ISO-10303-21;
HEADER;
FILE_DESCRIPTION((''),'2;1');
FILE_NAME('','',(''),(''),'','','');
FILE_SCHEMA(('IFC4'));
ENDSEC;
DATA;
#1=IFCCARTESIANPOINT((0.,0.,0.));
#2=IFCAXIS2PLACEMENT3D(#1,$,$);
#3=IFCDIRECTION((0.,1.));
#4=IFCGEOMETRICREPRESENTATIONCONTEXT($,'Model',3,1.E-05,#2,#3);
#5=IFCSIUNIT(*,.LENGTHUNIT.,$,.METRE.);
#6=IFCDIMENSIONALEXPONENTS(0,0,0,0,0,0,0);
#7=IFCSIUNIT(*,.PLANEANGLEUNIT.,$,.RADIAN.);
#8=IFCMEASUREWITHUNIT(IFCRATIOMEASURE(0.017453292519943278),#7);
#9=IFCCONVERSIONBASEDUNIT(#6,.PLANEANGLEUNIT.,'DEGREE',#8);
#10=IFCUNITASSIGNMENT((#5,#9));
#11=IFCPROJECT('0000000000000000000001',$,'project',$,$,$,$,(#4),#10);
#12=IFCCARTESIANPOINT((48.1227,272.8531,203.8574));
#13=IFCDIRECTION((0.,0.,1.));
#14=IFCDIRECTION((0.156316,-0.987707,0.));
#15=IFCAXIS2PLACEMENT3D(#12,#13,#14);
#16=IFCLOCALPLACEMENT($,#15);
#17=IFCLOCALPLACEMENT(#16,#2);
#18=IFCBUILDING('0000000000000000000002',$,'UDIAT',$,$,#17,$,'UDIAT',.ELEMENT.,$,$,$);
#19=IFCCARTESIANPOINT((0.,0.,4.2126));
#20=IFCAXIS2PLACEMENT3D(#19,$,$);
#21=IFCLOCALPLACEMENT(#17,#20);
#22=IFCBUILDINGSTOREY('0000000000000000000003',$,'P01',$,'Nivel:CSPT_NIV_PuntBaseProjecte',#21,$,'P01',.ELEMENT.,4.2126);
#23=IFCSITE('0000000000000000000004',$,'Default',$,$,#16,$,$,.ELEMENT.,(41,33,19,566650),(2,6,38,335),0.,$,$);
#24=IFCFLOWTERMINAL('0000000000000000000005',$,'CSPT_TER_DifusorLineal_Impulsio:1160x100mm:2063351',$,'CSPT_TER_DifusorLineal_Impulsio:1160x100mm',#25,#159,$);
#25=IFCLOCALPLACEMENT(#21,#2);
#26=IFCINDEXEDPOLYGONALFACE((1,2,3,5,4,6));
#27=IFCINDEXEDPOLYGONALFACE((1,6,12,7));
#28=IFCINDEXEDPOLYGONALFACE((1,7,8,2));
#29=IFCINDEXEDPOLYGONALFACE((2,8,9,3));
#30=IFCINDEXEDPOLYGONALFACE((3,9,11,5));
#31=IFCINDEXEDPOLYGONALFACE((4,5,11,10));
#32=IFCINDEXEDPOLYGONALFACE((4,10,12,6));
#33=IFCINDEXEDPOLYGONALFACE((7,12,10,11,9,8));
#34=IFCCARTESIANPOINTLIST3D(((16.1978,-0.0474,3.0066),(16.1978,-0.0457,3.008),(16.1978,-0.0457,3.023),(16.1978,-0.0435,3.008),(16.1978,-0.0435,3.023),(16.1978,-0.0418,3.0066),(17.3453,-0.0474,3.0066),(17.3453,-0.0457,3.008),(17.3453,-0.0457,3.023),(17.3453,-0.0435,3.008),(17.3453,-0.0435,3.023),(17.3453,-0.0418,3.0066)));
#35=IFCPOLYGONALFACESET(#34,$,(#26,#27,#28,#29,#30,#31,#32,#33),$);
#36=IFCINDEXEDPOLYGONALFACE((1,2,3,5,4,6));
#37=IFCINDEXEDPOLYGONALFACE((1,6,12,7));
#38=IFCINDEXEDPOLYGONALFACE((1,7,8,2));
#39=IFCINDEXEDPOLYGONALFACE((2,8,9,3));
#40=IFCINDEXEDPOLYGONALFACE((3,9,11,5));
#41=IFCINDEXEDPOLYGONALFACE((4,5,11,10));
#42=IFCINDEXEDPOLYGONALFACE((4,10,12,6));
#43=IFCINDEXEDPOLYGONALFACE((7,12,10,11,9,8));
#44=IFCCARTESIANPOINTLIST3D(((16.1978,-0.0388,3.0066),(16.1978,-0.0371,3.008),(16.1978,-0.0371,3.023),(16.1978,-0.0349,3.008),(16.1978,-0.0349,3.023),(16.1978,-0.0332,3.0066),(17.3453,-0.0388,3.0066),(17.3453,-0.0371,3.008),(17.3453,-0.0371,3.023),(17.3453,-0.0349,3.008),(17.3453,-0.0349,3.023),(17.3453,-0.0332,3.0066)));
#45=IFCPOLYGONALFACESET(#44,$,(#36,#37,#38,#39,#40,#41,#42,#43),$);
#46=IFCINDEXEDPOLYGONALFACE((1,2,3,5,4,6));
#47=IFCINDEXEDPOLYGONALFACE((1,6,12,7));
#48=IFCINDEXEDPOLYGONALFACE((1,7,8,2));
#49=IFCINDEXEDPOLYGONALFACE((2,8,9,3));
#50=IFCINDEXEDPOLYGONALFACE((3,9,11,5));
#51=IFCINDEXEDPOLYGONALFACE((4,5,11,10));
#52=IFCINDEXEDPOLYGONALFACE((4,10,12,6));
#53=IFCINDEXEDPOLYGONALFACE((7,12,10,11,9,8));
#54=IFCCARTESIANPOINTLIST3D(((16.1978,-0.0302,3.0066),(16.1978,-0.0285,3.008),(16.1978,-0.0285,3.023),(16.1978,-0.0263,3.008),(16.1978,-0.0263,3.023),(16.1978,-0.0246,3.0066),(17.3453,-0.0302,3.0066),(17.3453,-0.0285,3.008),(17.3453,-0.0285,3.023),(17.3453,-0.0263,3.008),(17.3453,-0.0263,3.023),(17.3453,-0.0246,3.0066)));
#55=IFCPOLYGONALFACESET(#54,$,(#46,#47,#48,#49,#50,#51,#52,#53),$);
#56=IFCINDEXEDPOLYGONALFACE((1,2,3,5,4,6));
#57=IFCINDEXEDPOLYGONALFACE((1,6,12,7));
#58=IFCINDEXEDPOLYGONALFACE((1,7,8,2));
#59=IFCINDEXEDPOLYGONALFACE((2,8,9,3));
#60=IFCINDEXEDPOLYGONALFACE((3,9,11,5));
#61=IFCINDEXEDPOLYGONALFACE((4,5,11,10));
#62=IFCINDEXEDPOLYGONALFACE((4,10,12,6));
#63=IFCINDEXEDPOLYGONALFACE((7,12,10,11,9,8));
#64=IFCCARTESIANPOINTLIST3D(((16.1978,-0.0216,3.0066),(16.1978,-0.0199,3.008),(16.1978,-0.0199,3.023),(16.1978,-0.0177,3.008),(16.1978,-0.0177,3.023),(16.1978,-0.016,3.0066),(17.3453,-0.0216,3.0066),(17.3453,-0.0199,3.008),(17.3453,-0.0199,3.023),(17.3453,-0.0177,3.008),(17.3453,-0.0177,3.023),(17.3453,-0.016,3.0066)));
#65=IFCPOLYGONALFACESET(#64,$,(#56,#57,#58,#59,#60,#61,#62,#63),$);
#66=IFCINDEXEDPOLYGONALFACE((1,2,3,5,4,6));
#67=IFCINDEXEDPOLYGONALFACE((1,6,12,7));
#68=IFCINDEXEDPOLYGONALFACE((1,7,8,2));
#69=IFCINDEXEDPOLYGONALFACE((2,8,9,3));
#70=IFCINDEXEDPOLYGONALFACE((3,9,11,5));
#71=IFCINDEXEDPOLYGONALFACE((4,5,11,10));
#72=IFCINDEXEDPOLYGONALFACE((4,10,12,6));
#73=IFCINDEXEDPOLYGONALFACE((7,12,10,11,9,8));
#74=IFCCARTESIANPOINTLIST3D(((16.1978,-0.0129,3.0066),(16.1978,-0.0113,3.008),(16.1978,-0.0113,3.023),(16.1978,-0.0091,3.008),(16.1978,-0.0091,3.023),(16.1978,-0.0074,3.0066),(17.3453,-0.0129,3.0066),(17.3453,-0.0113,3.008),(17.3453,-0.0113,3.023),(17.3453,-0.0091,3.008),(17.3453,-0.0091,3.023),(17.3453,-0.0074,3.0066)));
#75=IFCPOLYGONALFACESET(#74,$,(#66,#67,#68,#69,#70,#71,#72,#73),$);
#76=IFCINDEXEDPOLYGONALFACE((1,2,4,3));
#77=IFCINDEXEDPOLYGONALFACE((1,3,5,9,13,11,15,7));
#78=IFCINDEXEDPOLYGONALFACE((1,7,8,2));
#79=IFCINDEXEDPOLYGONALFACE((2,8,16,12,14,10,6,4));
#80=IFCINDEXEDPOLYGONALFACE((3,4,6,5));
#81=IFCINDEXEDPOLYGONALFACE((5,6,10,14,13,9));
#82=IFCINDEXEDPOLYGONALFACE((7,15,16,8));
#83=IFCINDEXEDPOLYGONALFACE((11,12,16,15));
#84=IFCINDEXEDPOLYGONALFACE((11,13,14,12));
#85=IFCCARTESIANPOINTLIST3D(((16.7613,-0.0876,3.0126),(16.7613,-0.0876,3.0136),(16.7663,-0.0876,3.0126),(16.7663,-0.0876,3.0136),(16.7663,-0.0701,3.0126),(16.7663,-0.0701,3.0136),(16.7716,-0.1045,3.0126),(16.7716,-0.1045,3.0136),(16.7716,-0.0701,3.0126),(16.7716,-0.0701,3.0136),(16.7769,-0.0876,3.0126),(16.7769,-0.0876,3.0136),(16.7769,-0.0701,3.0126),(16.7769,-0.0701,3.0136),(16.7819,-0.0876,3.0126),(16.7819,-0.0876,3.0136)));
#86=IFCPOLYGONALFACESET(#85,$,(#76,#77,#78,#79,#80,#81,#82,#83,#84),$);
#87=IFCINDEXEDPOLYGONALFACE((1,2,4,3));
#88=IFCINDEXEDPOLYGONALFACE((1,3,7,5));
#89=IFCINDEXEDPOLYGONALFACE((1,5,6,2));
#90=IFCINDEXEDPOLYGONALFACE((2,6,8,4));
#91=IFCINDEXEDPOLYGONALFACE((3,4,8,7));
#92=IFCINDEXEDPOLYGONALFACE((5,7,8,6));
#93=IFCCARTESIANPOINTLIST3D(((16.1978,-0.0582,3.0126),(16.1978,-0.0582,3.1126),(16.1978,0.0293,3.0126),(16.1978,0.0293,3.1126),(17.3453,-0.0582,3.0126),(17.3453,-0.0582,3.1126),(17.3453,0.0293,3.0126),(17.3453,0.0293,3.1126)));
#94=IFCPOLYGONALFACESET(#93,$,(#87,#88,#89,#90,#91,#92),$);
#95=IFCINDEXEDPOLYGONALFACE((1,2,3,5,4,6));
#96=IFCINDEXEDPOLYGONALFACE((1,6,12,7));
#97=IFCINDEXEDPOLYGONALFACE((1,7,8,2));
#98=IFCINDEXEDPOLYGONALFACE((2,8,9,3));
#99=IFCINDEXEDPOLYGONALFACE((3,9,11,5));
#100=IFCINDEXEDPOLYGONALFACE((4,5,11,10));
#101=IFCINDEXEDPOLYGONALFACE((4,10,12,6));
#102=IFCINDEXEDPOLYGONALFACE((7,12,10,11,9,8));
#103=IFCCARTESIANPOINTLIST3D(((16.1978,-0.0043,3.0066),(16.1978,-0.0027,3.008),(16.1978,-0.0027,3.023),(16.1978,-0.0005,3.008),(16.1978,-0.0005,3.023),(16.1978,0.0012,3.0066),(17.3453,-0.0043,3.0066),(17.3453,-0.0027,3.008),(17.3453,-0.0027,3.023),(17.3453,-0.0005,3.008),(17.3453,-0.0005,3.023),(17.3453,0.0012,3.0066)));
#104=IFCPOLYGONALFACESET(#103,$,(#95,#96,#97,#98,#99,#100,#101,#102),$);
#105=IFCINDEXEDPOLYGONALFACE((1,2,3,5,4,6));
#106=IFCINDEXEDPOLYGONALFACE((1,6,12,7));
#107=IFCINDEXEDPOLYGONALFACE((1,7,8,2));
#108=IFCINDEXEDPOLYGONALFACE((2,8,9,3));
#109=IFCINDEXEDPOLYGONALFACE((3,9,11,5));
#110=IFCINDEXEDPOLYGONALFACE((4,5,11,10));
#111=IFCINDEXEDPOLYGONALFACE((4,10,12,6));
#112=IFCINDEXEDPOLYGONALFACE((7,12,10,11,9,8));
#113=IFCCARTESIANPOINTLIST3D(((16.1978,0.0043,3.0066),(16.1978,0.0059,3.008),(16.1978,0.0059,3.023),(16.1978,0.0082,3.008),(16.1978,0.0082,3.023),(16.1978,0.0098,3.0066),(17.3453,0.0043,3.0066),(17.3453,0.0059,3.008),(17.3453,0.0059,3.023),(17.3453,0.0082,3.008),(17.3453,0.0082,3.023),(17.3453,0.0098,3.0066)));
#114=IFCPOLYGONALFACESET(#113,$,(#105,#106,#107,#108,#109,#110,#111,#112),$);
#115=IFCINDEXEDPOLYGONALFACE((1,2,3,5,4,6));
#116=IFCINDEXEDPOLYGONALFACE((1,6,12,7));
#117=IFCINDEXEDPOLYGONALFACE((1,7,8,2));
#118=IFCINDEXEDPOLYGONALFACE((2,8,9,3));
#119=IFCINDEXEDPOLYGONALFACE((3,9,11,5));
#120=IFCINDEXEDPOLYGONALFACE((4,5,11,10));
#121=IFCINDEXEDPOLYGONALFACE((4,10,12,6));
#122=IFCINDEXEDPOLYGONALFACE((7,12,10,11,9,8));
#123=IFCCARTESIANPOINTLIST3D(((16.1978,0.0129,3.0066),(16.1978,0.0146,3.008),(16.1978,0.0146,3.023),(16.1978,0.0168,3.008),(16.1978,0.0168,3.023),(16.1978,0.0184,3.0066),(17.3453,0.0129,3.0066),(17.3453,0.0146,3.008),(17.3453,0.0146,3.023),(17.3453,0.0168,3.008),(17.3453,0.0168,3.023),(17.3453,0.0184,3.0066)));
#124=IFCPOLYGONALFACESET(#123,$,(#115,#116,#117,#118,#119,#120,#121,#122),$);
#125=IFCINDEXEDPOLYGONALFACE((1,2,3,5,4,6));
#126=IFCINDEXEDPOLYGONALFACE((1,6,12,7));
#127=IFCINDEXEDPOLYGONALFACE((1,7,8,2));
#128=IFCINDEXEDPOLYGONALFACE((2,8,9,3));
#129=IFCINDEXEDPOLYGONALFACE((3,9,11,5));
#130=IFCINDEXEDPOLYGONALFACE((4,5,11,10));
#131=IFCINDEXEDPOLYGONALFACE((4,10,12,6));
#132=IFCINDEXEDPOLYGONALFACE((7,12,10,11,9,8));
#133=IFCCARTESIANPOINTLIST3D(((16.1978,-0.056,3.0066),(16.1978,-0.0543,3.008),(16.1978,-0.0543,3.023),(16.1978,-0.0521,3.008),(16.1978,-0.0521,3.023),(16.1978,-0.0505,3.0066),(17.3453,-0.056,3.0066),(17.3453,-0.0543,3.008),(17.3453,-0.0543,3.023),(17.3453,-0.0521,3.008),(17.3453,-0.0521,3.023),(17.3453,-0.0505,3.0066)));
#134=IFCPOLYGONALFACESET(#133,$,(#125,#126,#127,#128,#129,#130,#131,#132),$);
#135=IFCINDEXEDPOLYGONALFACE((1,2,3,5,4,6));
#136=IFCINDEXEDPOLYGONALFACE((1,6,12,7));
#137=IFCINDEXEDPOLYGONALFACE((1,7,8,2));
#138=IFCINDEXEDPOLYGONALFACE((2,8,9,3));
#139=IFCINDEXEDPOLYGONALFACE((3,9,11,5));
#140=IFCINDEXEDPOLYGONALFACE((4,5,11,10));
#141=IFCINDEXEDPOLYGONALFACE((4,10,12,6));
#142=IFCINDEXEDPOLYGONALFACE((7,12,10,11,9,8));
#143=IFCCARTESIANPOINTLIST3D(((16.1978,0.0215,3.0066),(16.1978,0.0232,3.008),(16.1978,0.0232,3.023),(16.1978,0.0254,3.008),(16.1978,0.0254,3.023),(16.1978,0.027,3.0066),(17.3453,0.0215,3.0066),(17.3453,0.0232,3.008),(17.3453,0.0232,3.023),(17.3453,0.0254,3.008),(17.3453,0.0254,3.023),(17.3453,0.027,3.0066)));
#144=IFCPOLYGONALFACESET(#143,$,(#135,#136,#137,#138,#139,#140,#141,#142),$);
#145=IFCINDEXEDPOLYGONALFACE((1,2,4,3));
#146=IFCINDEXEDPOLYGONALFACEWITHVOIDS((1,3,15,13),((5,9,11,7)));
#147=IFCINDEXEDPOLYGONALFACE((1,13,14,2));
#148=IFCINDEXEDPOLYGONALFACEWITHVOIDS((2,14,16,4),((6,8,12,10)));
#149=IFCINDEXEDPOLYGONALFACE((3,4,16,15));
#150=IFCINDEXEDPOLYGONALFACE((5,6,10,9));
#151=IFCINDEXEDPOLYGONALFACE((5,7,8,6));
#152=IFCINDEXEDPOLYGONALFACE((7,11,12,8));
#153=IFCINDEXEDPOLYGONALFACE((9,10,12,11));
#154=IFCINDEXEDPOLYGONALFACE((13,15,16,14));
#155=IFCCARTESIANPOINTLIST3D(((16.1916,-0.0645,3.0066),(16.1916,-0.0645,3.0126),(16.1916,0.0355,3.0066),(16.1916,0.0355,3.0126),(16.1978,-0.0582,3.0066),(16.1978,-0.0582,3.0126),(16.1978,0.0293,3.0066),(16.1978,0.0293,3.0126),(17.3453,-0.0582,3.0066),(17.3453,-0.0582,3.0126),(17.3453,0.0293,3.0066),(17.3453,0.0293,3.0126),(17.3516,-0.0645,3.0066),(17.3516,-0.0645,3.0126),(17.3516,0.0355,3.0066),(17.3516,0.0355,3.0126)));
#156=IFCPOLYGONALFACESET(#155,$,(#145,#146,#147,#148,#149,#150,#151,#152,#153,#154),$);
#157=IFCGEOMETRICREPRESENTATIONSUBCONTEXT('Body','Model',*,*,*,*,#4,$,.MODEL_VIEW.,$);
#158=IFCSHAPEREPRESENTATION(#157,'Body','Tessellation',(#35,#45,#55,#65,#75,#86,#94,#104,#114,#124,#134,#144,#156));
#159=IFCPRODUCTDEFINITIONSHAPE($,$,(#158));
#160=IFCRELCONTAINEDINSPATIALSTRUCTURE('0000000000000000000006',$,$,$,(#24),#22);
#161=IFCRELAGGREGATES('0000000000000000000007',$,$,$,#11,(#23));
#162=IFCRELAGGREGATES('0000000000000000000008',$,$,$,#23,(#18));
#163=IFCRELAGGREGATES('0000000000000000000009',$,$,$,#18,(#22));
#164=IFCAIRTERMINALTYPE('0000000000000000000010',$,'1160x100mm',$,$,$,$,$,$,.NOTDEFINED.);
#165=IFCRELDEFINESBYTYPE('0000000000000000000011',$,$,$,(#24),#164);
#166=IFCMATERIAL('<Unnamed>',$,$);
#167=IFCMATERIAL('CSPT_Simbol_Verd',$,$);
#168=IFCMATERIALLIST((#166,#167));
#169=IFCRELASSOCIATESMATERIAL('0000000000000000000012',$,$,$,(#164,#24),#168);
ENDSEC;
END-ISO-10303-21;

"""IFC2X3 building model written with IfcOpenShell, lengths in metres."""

from ifc_helpers import new_model, entity, si_unit, converted_unit, direction, frame, origin, origin_2d_with_axis, place, context, subcontext, project, spatial, polyline, rectangle, outline, extrude, source, transform, mapped, material, material_list, type_object, type_shapes, element, save


model = new_model("IFC2X3")

# Units and contexts
model_context = context("Model", 3, precision=1e-05, world=origin(), true_north=direction((0.0, 1.0)))
body_context = subcontext(model_context, "Body", "Model", "MODEL_VIEW")
ifc_project = project(units=[si_unit("LENGTHUNIT", "METRE"), converted_unit("PLANEANGLEUNIT", "DEGREE", entity("IfcRatioMeasure", 0.017453292519943278), si_unit("PLANEANGLEUNIT", "RADIAN"), dimensions=[0, 0, 0, 0, 0, 0, 0])], contexts=[model_context])

# Site, building, storey
site_placement = place(None, frame((48.1227, 272.8531, 203.8574), z_axis=(0.0, 0.0, 1.0), x_axis=(0.156316, -0.987707, 0.0)))
site = spatial("IfcSite", under=ifc_project, at=site_placement, Name="Default", CompositionType="ELEMENT", RefLatitude=(41, 33, 19, 566650), RefLongitude=(2, 6, 38, 335), RefElevation=0.0)
building_placement = place(site_placement, origin())
building = spatial("IfcBuilding", under=site, at=building_placement, Name="UDIAT", LongName="UDIAT", CompositionType="ELEMENT")
storey_placement = place(building_placement, frame((0.0, 0.0, 4.2126)))
storey = spatial("IfcBuildingStorey", under=building, at=storey_placement, Name="P01", ObjectType="Nivel:CSPT_NIV_PuntBaseProjecte", LongName="P01", CompositionType="ELEMENT", Elevation=4.2126)

# Shared definitions
ifc_material_1 = material(Name="<Unnamed>")

# Flow terminal
ifc_material_2 = material(Name="CSPT_Simbol_Verd")
ifc_material_list = material_list([ifc_material_1, ifc_material_2])
air_terminal_type = type_object("IfcAirTerminalType", Name="1160x100mm", PredefinedType="NOTDEFINED", material=ifc_material_list)
shared_shape_1 = source(origin(), body_context, "Body", "SweptSolid", [
    extrude(outline(polyline([(0.0037, 0.0028), (0.0059, 0.0028), (0.0016, 0.0063), (0.002, 0.0042), (-0.0074, -0.0074), (-0.0057, -0.0088), (0.0037, 0.0028)])), frame((-0.5737, 0.0301, -0.0001), z_axis=(1.0, 0.0, 0.0), x_axis=(0.0, -0.776119, -0.630587)), (0.0, 0.0, 1.0), 1.1475),
    extrude(outline(polyline([(0.0037, 0.0028), (0.0059, 0.0028), (0.0016, 0.0063), (0.002, 0.0042), (-0.0074, -0.0074), (-0.0057, -0.0088), (0.0037, 0.0028)])), frame((-0.5737, 0.0215, -0.0001), z_axis=(1.0, 0.0, 0.0), x_axis=(0.0, -0.776119, -0.630587)), (0.0, 0.0, 1.0), 1.1475),
    extrude(outline(polyline([(0.0037, 0.0028), (0.0059, 0.0028), (0.0016, 0.0063), (0.002, 0.0042), (-0.0074, -0.0074), (-0.0057, -0.0088), (0.0037, 0.0028)])), frame((-0.5737, 0.0129, -0.0001), z_axis=(1.0, 0.0, 0.0), x_axis=(0.0, -0.776119, -0.630587)), (0.0, 0.0, 1.0), 1.1475),
    extrude(outline(polyline([(0.0037, 0.0028), (0.0059, 0.0028), (0.0016, 0.0063), (0.002, 0.0042), (-0.0074, -0.0074), (-0.0057, -0.0088), (0.0037, 0.0028)])), frame((-0.5737, 0.0043, -0.0001), z_axis=(1.0, 0.0, 0.0), x_axis=(0.0, -0.776119, -0.630587)), (0.0, 0.0, 1.0), 1.1475),
    extrude(outline(polyline([(0.0037, 0.0028), (0.0059, 0.0028), (0.0016, 0.0063), (0.002, 0.0042), (-0.0074, -0.0074), (-0.0057, -0.0088), (0.0037, 0.0028)])), frame((-0.5737, -0.0043, -0.0001), z_axis=(1.0, 0.0, 0.0), x_axis=(0.0, -0.776119, -0.630587)), (0.0, 0.0, 1.0), 1.1475),
    extrude(outline(polyline([(0.0, -0.013), (0.0053, -0.013), (0.0053, 0.0045), (0.0103, 0.0045), (0.0, 0.0213), (-0.0103, 0.0045), (-0.0053, 0.0045), (-0.0053, -0.013), (0.0, -0.013)])), frame((0.0, 0.0687, 0.0)), (0.0, 0.0, 1.0), 0.001),
    extrude(rectangle(XDim=1.1475, YDim=0.0875, at=origin_2d_with_axis()), frame((0.0, 0.0, 0.0), z_axis=(0.0, 0.0, 1.0), x_axis=(-1.0, 0.0, 0.0)), (0.0, 0.0, 1.0), 0.1),
    extrude(outline(polyline([(0.0037, 0.0028), (0.0059, 0.0028), (0.0016, 0.0063), (0.002, 0.0042), (-0.0074, -0.0074), (-0.0057, -0.0088), (0.0037, 0.0028)])), frame((-0.5737, -0.0129, -0.0001), z_axis=(1.0, 0.0, 0.0), x_axis=(0.0, -0.776119, -0.630587)), (0.0, 0.0, 1.0), 1.1475),
    extrude(outline(polyline([(0.0037, 0.0028), (0.0059, 0.0028), (0.0016, 0.0063), (0.002, 0.0042), (-0.0074, -0.0074), (-0.0057, -0.0088), (0.0037, 0.0028)])), frame((-0.5737, -0.0215, -0.0001), z_axis=(1.0, 0.0, 0.0), x_axis=(0.0, -0.776119, -0.630587)), (0.0, 0.0, 1.0), 1.1475),
    extrude(outline(polyline([(0.0037, 0.0028), (0.0059, 0.0028), (0.0016, 0.0063), (0.002, 0.0042), (-0.0074, -0.0074), (-0.0057, -0.0088), (0.0037, 0.0028)])), frame((-0.5737, -0.0301, -0.0001), z_axis=(1.0, 0.0, 0.0), x_axis=(0.0, -0.776119, -0.630587)), (0.0, 0.0, 1.0), 1.1475),
    extrude(outline(polyline([(0.0037, 0.0028), (0.0059, 0.0028), (0.0016, 0.0063), (0.002, 0.0042), (-0.0074, -0.0074), (-0.0057, -0.0088), (0.0037, 0.0028)])), frame((-0.5737, 0.0388, -0.0001), z_axis=(1.0, 0.0, 0.0), x_axis=(0.0, -0.776119, -0.630587)), (0.0, 0.0, 1.0), 1.1475),
    extrude(outline(polyline([(0.0037, 0.0028), (0.0059, 0.0028), (0.0016, 0.0063), (0.002, 0.0042), (-0.0074, -0.0074), (-0.0057, -0.0088), (0.0037, 0.0028)])), frame((-0.5737, -0.0387, -0.0001), z_axis=(1.0, 0.0, 0.0), x_axis=(0.0, -0.776119, -0.630587)), (0.0, 0.0, 1.0), 1.1475),
    extrude(outline(polyline([(-0.58, -0.05), (0.58, -0.05), (0.58, 0.05), (-0.58, 0.05), (-0.58, -0.05)]), holes=[polyline([(-0.5738, -0.0438), (-0.5738, 0.0437), (0.5737, 0.0437), (0.5737, -0.0438), (-0.5738, -0.0438)])]), frame((0.0, 0.0, -0.006), z_axis=(0.0, 0.0, 1.0), x_axis=(-1.0, 0.0, 0.0)), (0.0, 0.0, 1.0), 0.006),
])
type_shapes(air_terminal_type, [shared_shape_1])
for number, where, z_axis, x_axis, name in (
    (1, (16.7716, -0.0145, 3.0126), (0.0, 0.0, 1.0), (-1.0, 0.0, 0.0), "CSPT_TER_DifusorLineal_Impulsio:1160x100mm:2063351"),
):
    element("IfcFlowTerminal", number, at=place(storey_placement, frame(where, z_axis=z_axis, x_axis=x_axis)), inside=storey, type_object=air_terminal_type, material=ifc_material_list, Name=name, ObjectType="CSPT_TER_DifusorLineal_Impulsio:1160x100mm", context=body_context, shape_type="MappedRepresentation", body=[
        mapped(shared_shape_1, transform((0.0, 0.0, 0.0), scale=1.0)),
    ])

save(model, "model.ifc")
